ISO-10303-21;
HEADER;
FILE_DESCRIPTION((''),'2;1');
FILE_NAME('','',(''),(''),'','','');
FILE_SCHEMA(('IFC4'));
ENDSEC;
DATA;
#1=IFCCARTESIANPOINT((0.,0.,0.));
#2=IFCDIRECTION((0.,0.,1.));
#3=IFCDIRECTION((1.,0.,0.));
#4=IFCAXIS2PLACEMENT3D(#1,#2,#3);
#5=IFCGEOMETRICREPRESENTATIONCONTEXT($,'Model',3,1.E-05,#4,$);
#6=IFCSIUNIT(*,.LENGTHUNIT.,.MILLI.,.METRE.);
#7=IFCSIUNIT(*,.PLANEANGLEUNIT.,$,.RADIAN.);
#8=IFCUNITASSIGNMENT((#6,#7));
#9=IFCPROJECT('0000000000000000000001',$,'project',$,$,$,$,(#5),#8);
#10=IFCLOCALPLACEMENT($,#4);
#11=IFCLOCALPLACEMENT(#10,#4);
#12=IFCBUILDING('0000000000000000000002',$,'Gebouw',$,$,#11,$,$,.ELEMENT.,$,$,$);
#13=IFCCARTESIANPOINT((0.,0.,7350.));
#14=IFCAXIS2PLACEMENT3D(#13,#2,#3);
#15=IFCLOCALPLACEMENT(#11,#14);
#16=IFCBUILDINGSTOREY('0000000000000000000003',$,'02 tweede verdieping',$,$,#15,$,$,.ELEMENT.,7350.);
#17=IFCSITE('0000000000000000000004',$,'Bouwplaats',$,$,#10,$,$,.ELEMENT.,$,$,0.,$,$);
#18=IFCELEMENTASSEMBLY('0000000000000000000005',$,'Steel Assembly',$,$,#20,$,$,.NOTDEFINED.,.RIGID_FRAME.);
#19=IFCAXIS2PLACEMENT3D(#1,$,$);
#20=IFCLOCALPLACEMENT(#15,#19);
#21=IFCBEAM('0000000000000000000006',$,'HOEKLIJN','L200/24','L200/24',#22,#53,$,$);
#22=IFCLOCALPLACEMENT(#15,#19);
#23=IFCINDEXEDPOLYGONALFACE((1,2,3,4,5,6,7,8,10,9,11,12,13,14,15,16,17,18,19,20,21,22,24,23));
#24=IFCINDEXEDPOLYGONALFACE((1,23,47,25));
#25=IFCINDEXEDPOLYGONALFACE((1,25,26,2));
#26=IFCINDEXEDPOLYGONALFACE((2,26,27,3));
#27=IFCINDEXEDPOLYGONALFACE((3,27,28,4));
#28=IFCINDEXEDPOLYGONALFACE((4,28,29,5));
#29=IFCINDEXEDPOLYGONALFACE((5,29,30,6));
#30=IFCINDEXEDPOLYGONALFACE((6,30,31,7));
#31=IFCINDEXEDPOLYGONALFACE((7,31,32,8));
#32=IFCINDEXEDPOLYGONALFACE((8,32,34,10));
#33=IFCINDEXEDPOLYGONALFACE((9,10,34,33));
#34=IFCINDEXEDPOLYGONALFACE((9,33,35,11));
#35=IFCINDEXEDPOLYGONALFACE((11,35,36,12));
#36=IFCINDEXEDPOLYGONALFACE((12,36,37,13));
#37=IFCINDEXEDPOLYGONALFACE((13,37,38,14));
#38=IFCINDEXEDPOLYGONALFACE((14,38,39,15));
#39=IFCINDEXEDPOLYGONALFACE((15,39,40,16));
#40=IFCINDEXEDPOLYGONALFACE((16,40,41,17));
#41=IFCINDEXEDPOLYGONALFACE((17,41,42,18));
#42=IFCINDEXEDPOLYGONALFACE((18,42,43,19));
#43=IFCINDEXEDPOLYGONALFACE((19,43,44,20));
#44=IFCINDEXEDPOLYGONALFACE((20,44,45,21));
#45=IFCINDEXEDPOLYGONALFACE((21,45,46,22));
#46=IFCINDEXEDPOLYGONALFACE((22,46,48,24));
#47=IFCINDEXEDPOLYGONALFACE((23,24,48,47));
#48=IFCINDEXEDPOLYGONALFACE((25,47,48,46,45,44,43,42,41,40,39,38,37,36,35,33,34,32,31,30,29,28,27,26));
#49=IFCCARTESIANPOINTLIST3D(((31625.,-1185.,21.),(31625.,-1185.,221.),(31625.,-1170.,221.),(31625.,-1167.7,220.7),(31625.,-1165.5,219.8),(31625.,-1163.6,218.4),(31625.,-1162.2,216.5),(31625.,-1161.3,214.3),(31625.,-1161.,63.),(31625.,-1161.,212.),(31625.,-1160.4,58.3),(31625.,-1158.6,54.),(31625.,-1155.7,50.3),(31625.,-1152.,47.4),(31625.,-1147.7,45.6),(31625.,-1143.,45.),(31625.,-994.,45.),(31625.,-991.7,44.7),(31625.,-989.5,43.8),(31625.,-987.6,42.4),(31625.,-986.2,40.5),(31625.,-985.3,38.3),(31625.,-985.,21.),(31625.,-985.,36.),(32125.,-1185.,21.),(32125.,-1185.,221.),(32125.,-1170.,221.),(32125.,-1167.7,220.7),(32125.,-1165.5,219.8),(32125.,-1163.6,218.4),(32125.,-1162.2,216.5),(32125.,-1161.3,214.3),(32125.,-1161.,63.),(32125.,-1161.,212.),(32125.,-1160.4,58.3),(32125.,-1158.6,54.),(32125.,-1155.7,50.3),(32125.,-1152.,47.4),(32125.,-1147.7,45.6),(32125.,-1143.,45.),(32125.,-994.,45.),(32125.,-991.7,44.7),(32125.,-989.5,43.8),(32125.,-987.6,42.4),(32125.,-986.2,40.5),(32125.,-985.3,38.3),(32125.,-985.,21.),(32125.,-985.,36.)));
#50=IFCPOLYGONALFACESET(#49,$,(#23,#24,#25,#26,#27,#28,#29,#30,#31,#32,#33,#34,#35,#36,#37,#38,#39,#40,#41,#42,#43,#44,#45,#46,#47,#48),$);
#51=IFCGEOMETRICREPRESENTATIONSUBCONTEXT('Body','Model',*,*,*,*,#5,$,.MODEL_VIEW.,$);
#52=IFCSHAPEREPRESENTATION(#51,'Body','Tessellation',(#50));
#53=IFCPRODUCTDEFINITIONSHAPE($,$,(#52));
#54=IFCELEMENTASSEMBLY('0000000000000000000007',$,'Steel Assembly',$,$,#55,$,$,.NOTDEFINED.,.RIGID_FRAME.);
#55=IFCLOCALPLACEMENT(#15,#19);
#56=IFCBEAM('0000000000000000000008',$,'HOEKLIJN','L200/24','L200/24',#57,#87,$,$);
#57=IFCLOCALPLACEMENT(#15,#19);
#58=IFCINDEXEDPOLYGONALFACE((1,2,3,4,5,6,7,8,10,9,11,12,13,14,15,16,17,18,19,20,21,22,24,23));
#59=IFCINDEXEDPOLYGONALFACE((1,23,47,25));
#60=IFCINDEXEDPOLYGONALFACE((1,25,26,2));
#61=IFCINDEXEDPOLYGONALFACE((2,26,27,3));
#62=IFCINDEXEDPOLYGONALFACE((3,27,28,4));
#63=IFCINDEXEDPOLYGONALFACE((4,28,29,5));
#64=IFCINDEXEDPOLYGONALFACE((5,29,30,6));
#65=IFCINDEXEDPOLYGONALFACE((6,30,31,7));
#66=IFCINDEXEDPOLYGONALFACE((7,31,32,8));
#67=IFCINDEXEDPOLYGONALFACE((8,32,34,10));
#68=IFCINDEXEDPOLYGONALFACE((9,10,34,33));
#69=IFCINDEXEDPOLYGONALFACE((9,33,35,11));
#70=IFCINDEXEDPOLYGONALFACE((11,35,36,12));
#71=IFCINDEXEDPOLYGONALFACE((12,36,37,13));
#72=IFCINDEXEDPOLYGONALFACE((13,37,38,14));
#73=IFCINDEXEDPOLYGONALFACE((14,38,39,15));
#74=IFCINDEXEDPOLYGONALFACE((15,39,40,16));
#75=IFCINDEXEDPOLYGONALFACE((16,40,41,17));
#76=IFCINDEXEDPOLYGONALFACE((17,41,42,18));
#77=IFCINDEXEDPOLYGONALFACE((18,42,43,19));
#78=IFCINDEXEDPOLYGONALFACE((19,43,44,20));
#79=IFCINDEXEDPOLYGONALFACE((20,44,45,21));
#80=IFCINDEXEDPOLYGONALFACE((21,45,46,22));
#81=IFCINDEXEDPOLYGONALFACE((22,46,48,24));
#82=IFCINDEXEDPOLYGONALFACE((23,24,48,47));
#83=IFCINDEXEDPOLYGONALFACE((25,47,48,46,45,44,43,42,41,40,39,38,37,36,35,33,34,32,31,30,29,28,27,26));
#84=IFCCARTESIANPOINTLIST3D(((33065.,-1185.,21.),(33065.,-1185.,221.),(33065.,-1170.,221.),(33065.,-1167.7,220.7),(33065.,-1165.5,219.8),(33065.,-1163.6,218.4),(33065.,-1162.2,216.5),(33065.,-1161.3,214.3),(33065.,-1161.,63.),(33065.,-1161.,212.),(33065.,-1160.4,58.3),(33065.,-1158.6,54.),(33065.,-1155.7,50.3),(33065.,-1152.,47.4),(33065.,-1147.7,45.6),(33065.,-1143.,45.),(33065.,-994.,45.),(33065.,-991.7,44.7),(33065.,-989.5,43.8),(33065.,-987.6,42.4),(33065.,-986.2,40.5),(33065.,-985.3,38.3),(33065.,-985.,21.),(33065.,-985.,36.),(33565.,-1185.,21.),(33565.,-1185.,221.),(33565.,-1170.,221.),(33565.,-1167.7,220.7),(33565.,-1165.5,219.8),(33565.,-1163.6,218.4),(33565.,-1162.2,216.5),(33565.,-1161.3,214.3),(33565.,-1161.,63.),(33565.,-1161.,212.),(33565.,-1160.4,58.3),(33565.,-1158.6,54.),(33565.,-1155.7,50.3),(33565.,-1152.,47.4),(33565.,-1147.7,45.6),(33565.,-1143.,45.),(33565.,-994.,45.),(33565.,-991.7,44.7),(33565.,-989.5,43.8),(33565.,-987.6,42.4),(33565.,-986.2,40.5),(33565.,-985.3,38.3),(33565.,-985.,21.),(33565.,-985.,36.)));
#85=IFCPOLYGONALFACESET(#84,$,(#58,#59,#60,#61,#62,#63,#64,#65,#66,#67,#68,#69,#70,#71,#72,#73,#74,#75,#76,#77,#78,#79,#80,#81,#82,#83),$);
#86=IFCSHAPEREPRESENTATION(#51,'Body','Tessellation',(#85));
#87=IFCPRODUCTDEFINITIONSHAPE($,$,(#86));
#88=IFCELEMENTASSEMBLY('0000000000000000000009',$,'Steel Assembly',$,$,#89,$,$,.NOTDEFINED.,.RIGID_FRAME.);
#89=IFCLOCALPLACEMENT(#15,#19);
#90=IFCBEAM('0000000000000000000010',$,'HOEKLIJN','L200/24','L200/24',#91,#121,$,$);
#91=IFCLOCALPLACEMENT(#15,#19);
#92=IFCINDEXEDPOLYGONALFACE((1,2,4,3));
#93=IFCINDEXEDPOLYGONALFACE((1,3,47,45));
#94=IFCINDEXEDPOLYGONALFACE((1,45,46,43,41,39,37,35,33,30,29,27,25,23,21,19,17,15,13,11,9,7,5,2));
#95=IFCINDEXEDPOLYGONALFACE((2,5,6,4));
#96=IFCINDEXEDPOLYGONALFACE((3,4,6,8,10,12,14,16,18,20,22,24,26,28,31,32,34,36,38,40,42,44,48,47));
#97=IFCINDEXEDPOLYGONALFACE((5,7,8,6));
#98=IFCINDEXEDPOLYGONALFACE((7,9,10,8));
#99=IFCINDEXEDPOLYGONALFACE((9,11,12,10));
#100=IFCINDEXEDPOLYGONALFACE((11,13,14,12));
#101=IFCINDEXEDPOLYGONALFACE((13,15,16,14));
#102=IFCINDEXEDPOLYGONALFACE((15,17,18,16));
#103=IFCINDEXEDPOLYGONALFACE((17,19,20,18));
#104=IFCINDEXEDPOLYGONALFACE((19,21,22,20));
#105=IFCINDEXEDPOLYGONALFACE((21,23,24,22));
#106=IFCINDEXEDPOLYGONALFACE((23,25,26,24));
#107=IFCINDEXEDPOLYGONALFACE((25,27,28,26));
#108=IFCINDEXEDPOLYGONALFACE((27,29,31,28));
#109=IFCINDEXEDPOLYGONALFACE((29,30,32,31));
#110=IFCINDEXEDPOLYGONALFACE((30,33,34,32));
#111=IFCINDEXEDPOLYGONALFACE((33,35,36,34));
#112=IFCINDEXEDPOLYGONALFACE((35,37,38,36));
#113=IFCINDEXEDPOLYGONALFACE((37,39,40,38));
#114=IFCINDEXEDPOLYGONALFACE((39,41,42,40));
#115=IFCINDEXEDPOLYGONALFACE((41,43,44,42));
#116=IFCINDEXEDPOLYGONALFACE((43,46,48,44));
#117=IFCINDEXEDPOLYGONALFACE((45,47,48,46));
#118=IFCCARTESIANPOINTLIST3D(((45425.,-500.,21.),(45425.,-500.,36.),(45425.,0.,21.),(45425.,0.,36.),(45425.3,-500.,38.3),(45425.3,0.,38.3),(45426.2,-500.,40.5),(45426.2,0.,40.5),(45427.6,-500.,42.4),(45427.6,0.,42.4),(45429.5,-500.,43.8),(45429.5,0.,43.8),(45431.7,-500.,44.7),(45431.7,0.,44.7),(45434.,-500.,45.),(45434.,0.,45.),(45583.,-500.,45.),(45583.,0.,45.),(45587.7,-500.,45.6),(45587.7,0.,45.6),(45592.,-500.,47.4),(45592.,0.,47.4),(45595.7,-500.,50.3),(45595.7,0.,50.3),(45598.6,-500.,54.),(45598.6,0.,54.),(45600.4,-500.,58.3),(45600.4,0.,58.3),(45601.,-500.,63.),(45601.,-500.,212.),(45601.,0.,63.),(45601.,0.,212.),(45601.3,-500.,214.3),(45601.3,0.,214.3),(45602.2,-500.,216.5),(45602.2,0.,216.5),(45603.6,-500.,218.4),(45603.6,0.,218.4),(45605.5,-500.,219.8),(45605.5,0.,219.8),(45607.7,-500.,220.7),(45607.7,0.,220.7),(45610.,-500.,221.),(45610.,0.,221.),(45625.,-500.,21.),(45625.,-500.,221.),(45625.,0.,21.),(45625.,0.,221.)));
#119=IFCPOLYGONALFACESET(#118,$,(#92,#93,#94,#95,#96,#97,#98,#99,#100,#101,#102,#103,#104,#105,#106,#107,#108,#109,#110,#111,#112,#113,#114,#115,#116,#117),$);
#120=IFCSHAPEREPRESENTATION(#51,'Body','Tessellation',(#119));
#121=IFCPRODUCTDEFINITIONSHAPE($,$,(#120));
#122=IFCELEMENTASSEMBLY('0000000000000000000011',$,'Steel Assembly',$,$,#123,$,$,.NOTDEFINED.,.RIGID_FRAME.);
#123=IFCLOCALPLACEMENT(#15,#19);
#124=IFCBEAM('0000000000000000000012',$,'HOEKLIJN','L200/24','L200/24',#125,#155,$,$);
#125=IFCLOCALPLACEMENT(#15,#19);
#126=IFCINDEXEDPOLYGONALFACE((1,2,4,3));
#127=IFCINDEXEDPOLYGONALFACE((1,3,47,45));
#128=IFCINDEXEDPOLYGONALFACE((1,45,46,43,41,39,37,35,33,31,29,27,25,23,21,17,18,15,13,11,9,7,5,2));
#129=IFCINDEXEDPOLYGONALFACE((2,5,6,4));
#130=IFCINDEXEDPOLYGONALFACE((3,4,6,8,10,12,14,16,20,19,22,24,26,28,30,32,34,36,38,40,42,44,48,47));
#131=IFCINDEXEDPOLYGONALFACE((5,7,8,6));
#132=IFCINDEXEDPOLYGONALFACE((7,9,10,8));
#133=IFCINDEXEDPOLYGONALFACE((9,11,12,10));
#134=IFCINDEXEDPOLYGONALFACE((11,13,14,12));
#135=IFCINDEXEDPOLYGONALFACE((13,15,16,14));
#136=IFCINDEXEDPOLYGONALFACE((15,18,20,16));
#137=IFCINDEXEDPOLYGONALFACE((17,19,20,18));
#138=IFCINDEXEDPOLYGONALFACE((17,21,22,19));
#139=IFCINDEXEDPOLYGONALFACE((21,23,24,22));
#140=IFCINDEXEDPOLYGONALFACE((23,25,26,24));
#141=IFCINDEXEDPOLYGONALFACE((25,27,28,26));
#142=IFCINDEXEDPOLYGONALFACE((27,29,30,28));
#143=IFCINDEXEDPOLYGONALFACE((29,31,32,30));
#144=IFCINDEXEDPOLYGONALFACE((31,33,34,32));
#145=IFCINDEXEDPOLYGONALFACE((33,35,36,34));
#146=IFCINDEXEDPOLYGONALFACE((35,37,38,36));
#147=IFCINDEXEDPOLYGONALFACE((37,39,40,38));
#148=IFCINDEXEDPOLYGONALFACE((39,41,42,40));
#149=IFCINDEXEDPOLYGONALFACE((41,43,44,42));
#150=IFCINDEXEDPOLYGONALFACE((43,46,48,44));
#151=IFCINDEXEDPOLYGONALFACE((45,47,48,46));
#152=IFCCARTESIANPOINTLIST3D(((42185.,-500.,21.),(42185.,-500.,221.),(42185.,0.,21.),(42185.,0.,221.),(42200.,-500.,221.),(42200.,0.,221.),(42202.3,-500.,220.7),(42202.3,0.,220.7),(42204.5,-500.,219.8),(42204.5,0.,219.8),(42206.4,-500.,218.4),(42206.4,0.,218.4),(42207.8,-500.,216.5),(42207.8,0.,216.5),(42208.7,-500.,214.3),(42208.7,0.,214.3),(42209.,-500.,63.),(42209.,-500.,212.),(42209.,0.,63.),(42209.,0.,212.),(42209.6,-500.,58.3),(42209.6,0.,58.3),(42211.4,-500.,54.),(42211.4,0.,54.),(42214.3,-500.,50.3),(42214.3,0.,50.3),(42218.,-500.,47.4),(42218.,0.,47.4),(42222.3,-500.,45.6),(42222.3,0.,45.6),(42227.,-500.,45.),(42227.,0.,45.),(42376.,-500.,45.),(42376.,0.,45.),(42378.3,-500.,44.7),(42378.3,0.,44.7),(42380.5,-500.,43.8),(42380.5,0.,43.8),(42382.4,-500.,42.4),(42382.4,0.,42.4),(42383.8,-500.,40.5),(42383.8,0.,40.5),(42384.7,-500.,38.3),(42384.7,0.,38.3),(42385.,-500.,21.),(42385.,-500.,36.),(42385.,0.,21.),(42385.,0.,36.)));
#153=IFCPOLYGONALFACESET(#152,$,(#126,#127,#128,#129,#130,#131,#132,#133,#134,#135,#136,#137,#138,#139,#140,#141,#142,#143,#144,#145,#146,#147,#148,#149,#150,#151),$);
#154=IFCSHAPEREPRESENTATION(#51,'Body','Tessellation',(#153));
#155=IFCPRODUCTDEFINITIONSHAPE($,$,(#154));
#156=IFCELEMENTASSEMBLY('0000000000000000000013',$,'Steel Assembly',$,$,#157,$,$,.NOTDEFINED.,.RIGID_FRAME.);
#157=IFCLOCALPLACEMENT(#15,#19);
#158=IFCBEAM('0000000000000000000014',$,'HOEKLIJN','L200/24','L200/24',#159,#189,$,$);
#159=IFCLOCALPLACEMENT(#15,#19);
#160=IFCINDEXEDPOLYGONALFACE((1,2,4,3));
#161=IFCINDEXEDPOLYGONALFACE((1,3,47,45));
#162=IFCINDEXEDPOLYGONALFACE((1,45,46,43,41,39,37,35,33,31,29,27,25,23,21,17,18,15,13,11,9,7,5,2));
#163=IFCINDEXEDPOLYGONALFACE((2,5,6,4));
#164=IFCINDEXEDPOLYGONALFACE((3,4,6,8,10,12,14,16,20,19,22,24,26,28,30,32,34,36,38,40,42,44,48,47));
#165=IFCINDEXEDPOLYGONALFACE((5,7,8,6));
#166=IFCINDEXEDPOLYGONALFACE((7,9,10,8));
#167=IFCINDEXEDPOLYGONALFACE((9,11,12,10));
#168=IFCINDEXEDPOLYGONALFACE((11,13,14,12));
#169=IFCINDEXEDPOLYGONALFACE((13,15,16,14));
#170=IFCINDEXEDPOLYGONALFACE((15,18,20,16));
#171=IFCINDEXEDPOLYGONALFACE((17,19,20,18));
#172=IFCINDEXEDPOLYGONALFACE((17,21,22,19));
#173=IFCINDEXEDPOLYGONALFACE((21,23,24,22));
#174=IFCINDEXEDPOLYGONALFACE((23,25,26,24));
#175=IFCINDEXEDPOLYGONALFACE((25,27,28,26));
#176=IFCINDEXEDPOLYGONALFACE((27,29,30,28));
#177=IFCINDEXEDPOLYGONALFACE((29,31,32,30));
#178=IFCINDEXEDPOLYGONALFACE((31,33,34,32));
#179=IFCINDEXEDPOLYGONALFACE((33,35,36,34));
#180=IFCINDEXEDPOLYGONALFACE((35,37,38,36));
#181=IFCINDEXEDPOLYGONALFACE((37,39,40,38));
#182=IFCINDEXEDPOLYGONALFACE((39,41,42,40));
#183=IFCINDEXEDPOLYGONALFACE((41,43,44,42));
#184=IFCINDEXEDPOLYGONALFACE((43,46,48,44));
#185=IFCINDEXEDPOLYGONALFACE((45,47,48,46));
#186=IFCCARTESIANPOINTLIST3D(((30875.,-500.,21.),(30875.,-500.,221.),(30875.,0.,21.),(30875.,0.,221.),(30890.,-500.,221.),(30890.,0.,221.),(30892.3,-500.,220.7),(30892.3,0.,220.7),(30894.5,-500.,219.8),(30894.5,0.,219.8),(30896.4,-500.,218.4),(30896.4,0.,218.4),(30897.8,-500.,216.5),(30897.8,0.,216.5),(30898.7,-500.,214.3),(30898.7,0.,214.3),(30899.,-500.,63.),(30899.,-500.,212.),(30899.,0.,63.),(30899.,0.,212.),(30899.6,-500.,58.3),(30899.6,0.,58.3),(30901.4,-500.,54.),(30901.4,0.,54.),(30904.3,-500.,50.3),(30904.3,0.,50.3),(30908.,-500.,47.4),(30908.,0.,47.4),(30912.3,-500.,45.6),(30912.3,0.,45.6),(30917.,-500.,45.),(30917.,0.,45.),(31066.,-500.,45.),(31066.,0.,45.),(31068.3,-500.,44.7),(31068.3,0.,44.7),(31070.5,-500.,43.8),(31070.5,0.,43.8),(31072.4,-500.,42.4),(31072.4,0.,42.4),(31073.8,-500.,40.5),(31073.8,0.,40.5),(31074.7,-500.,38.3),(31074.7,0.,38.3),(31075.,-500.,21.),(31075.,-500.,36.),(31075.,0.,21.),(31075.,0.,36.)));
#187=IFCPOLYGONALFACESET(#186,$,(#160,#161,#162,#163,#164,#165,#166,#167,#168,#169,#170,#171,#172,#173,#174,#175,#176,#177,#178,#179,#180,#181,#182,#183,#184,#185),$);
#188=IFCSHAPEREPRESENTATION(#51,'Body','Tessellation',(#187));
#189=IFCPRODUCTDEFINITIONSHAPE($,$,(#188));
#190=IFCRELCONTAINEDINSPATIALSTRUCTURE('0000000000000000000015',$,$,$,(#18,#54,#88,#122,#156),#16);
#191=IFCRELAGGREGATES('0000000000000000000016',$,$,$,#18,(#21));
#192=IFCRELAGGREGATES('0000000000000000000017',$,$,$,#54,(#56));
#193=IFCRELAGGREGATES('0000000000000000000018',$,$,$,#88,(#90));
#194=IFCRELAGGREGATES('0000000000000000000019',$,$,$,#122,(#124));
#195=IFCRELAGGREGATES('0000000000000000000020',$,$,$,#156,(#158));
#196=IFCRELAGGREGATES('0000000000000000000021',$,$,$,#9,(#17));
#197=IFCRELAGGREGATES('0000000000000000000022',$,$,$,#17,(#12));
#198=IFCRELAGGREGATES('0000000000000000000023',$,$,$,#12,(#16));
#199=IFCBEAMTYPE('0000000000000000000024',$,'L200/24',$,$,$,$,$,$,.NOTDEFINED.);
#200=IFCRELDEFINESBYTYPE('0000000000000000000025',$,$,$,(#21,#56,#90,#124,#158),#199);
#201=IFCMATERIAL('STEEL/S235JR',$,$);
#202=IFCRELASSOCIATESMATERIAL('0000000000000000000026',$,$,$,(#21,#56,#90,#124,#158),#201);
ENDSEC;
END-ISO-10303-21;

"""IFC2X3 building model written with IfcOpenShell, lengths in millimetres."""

from ifc_helpers import new_model, si_unit, frame, origin_with_axes, origin_2d_with_axis, place, context, subcontext, project, spatial, l_section, extrude, material, type_object, element, aggregate, save


model = new_model("IFC2X3")

# Units and contexts
model_context = context("Model", 3, precision=1e-05, world=origin_with_axes())
body_context = subcontext(model_context, "Body", "Model", "MODEL_VIEW")
ifc_project = project(units=[si_unit("LENGTHUNIT", "METRE", prefix="MILLI"), si_unit("PLANEANGLEUNIT", "RADIAN")], contexts=[model_context])

# Site, building, storey
site_placement = place(None, origin_with_axes())
site = spatial("IfcSite", under=ifc_project, at=site_placement, Name="Bouwplaats", CompositionType="ELEMENT", RefElevation=0.0)
building_placement = place(site_placement, origin_with_axes())
building = spatial("IfcBuilding", under=site, at=building_placement, Name="Gebouw", CompositionType="ELEMENT")
storey_placement = place(building_placement, frame((0.0, 0.0, 7350.0), z_axis=(0.0, 0.0, 1.0), x_axis=(1.0, 0.0, 0.0)))
storey = spatial("IfcBuildingStorey", under=building, at=storey_placement, Name="02 tweede verdieping", CompositionType="ELEMENT", Elevation=7350.0)

# Shared definitions
ifc_material_1 = material(Name="STEEL/S235JR")

# Element assemblies, beams
beam_type_1 = type_object("IfcBeamType", Name="L200/24", PredefinedType="NOTDEFINED")
assembly_1_placement = place(storey_placement, origin_with_axes())
assembly_1 = element("IfcElementAssembly", 1, at=assembly_1_placement, inside=storey, Name="Steel Assembly", AssemblyPlace="NOTDEFINED", PredefinedType="RIGID_FRAME")
beam_1_placement = place(assembly_1_placement, frame((31625.0, -1085.0, 121.0), z_axis=(0.0, 1.0, 0.0), x_axis=(1.0, 0.0, 0.0)))
beam_1 = element("IfcBeam", 2, at=beam_1_placement, type_object=beam_type_1, material=ifc_material_1, Name="HOEKLIJN", Description="L200/24", ObjectType="L200/24", context=body_context, shape_type="SweptSolid", body=[
    extrude(l_section(Depth=200.0, Width=200.0, Thickness=24.0, FilletRadius=18.0, EdgeRadius=9.0, at=origin_2d_with_axis()), frame((500.0, 0.0, 0.0), z_axis=(-1.0, 0.0, 0.0), x_axis=(0.0, -1.0, 0.0)), (0.0, 0.0, 1.0), 500.0),
])
aggregate(assembly_1, [beam_1])
assembly_2_placement = place(storey_placement, origin_with_axes())
assembly_2 = element("IfcElementAssembly", 3, at=assembly_2_placement, inside=storey, Name="Steel Assembly", AssemblyPlace="NOTDEFINED", PredefinedType="RIGID_FRAME")
beam_2_placement = place(assembly_2_placement, frame((33065.0, -1085.0, 121.0), z_axis=(0.0, 1.0, 0.0), x_axis=(1.0, 0.0, 0.0)))
beam_2 = element("IfcBeam", 4, at=beam_2_placement, type_object=beam_type_1, material=ifc_material_1, Name="HOEKLIJN", Description="L200/24", ObjectType="L200/24", context=body_context, shape_type="SweptSolid", body=[
    extrude(l_section(Depth=200.0, Width=200.0, Thickness=24.0, FilletRadius=18.0, EdgeRadius=9.0, at=origin_2d_with_axis()), frame((500.0, 0.0, 0.0), z_axis=(-1.0, 0.0, 0.0), x_axis=(0.0, -1.0, 0.0)), (0.0, 0.0, 1.0), 500.0),
])
aggregate(assembly_2, [beam_2])
assembly_3_placement = place(storey_placement, origin_with_axes())
assembly_3 = element("IfcElementAssembly", 5, at=assembly_3_placement, inside=storey, Name="Steel Assembly", AssemblyPlace="NOTDEFINED", PredefinedType="RIGID_FRAME")
beam_3_placement = place(assembly_3_placement, frame((45525.0, -500.0, 121.0), z_axis=(-1.0, 0.0, 0.0), x_axis=(0.0, 1.0, 0.0)))
beam_3 = element("IfcBeam", 6, at=beam_3_placement, type_object=beam_type_1, material=ifc_material_1, Name="HOEKLIJN", Description="L200/24", ObjectType="L200/24", context=body_context, shape_type="SweptSolid", body=[
    extrude(l_section(Depth=200.0, Width=200.0, Thickness=24.0, FilletRadius=18.0, EdgeRadius=9.0, at=origin_2d_with_axis()), frame((500.0, 0.0, 0.0), z_axis=(-1.0, 0.0, 0.0), x_axis=(0.0, -1.0, 0.0)), (0.0, 0.0, 1.0), 500.0),
])
aggregate(assembly_3, [beam_3])
assembly_4_placement = place(storey_placement, origin_with_axes())
assembly_4 = element("IfcElementAssembly", 7, at=assembly_4_placement, inside=storey, Name="Steel Assembly", AssemblyPlace="NOTDEFINED", PredefinedType="RIGID_FRAME")
beam_4_placement = place(assembly_4_placement, frame((42285.0, 0.0, 121.0), z_axis=(1.0, 0.0, 0.0), x_axis=(0.0, -1.0, 0.0)))
beam_4 = element("IfcBeam", 8, at=beam_4_placement, type_object=beam_type_1, material=ifc_material_1, Name="HOEKLIJN", Description="L200/24", ObjectType="L200/24", context=body_context, shape_type="SweptSolid", body=[
    extrude(l_section(Depth=200.0, Width=200.0, Thickness=24.0, FilletRadius=18.0, EdgeRadius=9.0, at=origin_2d_with_axis()), frame((500.0, 0.0, 0.0), z_axis=(-1.0, 0.0, 0.0), x_axis=(0.0, -1.0, 0.0)), (0.0, 0.0, 1.0), 500.0),
])
aggregate(assembly_4, [beam_4])
assembly_5_placement = place(storey_placement, origin_with_axes())
assembly_5 = element("IfcElementAssembly", 9, at=assembly_5_placement, inside=storey, Name="Steel Assembly", AssemblyPlace="NOTDEFINED", PredefinedType="RIGID_FRAME")
beam_5_placement = place(assembly_5_placement, frame((30975.0, 0.0, 121.0), z_axis=(1.0, 0.0, 0.0), x_axis=(0.0, -1.0, 0.0)))
beam_5 = element("IfcBeam", 10, at=beam_5_placement, type_object=beam_type_1, material=ifc_material_1, Name="HOEKLIJN", Description="L200/24", ObjectType="L200/24", context=body_context, shape_type="SweptSolid", body=[
    extrude(l_section(Depth=200.0, Width=200.0, Thickness=24.0, FilletRadius=18.0, EdgeRadius=9.0, at=origin_2d_with_axis()), frame((500.0, 0.0, 0.0), z_axis=(-1.0, 0.0, 0.0), x_axis=(0.0, -1.0, 0.0)), (0.0, 0.0, 1.0), 500.0),
])
aggregate(assembly_5, [beam_5])

save(model, "model.ifc")
